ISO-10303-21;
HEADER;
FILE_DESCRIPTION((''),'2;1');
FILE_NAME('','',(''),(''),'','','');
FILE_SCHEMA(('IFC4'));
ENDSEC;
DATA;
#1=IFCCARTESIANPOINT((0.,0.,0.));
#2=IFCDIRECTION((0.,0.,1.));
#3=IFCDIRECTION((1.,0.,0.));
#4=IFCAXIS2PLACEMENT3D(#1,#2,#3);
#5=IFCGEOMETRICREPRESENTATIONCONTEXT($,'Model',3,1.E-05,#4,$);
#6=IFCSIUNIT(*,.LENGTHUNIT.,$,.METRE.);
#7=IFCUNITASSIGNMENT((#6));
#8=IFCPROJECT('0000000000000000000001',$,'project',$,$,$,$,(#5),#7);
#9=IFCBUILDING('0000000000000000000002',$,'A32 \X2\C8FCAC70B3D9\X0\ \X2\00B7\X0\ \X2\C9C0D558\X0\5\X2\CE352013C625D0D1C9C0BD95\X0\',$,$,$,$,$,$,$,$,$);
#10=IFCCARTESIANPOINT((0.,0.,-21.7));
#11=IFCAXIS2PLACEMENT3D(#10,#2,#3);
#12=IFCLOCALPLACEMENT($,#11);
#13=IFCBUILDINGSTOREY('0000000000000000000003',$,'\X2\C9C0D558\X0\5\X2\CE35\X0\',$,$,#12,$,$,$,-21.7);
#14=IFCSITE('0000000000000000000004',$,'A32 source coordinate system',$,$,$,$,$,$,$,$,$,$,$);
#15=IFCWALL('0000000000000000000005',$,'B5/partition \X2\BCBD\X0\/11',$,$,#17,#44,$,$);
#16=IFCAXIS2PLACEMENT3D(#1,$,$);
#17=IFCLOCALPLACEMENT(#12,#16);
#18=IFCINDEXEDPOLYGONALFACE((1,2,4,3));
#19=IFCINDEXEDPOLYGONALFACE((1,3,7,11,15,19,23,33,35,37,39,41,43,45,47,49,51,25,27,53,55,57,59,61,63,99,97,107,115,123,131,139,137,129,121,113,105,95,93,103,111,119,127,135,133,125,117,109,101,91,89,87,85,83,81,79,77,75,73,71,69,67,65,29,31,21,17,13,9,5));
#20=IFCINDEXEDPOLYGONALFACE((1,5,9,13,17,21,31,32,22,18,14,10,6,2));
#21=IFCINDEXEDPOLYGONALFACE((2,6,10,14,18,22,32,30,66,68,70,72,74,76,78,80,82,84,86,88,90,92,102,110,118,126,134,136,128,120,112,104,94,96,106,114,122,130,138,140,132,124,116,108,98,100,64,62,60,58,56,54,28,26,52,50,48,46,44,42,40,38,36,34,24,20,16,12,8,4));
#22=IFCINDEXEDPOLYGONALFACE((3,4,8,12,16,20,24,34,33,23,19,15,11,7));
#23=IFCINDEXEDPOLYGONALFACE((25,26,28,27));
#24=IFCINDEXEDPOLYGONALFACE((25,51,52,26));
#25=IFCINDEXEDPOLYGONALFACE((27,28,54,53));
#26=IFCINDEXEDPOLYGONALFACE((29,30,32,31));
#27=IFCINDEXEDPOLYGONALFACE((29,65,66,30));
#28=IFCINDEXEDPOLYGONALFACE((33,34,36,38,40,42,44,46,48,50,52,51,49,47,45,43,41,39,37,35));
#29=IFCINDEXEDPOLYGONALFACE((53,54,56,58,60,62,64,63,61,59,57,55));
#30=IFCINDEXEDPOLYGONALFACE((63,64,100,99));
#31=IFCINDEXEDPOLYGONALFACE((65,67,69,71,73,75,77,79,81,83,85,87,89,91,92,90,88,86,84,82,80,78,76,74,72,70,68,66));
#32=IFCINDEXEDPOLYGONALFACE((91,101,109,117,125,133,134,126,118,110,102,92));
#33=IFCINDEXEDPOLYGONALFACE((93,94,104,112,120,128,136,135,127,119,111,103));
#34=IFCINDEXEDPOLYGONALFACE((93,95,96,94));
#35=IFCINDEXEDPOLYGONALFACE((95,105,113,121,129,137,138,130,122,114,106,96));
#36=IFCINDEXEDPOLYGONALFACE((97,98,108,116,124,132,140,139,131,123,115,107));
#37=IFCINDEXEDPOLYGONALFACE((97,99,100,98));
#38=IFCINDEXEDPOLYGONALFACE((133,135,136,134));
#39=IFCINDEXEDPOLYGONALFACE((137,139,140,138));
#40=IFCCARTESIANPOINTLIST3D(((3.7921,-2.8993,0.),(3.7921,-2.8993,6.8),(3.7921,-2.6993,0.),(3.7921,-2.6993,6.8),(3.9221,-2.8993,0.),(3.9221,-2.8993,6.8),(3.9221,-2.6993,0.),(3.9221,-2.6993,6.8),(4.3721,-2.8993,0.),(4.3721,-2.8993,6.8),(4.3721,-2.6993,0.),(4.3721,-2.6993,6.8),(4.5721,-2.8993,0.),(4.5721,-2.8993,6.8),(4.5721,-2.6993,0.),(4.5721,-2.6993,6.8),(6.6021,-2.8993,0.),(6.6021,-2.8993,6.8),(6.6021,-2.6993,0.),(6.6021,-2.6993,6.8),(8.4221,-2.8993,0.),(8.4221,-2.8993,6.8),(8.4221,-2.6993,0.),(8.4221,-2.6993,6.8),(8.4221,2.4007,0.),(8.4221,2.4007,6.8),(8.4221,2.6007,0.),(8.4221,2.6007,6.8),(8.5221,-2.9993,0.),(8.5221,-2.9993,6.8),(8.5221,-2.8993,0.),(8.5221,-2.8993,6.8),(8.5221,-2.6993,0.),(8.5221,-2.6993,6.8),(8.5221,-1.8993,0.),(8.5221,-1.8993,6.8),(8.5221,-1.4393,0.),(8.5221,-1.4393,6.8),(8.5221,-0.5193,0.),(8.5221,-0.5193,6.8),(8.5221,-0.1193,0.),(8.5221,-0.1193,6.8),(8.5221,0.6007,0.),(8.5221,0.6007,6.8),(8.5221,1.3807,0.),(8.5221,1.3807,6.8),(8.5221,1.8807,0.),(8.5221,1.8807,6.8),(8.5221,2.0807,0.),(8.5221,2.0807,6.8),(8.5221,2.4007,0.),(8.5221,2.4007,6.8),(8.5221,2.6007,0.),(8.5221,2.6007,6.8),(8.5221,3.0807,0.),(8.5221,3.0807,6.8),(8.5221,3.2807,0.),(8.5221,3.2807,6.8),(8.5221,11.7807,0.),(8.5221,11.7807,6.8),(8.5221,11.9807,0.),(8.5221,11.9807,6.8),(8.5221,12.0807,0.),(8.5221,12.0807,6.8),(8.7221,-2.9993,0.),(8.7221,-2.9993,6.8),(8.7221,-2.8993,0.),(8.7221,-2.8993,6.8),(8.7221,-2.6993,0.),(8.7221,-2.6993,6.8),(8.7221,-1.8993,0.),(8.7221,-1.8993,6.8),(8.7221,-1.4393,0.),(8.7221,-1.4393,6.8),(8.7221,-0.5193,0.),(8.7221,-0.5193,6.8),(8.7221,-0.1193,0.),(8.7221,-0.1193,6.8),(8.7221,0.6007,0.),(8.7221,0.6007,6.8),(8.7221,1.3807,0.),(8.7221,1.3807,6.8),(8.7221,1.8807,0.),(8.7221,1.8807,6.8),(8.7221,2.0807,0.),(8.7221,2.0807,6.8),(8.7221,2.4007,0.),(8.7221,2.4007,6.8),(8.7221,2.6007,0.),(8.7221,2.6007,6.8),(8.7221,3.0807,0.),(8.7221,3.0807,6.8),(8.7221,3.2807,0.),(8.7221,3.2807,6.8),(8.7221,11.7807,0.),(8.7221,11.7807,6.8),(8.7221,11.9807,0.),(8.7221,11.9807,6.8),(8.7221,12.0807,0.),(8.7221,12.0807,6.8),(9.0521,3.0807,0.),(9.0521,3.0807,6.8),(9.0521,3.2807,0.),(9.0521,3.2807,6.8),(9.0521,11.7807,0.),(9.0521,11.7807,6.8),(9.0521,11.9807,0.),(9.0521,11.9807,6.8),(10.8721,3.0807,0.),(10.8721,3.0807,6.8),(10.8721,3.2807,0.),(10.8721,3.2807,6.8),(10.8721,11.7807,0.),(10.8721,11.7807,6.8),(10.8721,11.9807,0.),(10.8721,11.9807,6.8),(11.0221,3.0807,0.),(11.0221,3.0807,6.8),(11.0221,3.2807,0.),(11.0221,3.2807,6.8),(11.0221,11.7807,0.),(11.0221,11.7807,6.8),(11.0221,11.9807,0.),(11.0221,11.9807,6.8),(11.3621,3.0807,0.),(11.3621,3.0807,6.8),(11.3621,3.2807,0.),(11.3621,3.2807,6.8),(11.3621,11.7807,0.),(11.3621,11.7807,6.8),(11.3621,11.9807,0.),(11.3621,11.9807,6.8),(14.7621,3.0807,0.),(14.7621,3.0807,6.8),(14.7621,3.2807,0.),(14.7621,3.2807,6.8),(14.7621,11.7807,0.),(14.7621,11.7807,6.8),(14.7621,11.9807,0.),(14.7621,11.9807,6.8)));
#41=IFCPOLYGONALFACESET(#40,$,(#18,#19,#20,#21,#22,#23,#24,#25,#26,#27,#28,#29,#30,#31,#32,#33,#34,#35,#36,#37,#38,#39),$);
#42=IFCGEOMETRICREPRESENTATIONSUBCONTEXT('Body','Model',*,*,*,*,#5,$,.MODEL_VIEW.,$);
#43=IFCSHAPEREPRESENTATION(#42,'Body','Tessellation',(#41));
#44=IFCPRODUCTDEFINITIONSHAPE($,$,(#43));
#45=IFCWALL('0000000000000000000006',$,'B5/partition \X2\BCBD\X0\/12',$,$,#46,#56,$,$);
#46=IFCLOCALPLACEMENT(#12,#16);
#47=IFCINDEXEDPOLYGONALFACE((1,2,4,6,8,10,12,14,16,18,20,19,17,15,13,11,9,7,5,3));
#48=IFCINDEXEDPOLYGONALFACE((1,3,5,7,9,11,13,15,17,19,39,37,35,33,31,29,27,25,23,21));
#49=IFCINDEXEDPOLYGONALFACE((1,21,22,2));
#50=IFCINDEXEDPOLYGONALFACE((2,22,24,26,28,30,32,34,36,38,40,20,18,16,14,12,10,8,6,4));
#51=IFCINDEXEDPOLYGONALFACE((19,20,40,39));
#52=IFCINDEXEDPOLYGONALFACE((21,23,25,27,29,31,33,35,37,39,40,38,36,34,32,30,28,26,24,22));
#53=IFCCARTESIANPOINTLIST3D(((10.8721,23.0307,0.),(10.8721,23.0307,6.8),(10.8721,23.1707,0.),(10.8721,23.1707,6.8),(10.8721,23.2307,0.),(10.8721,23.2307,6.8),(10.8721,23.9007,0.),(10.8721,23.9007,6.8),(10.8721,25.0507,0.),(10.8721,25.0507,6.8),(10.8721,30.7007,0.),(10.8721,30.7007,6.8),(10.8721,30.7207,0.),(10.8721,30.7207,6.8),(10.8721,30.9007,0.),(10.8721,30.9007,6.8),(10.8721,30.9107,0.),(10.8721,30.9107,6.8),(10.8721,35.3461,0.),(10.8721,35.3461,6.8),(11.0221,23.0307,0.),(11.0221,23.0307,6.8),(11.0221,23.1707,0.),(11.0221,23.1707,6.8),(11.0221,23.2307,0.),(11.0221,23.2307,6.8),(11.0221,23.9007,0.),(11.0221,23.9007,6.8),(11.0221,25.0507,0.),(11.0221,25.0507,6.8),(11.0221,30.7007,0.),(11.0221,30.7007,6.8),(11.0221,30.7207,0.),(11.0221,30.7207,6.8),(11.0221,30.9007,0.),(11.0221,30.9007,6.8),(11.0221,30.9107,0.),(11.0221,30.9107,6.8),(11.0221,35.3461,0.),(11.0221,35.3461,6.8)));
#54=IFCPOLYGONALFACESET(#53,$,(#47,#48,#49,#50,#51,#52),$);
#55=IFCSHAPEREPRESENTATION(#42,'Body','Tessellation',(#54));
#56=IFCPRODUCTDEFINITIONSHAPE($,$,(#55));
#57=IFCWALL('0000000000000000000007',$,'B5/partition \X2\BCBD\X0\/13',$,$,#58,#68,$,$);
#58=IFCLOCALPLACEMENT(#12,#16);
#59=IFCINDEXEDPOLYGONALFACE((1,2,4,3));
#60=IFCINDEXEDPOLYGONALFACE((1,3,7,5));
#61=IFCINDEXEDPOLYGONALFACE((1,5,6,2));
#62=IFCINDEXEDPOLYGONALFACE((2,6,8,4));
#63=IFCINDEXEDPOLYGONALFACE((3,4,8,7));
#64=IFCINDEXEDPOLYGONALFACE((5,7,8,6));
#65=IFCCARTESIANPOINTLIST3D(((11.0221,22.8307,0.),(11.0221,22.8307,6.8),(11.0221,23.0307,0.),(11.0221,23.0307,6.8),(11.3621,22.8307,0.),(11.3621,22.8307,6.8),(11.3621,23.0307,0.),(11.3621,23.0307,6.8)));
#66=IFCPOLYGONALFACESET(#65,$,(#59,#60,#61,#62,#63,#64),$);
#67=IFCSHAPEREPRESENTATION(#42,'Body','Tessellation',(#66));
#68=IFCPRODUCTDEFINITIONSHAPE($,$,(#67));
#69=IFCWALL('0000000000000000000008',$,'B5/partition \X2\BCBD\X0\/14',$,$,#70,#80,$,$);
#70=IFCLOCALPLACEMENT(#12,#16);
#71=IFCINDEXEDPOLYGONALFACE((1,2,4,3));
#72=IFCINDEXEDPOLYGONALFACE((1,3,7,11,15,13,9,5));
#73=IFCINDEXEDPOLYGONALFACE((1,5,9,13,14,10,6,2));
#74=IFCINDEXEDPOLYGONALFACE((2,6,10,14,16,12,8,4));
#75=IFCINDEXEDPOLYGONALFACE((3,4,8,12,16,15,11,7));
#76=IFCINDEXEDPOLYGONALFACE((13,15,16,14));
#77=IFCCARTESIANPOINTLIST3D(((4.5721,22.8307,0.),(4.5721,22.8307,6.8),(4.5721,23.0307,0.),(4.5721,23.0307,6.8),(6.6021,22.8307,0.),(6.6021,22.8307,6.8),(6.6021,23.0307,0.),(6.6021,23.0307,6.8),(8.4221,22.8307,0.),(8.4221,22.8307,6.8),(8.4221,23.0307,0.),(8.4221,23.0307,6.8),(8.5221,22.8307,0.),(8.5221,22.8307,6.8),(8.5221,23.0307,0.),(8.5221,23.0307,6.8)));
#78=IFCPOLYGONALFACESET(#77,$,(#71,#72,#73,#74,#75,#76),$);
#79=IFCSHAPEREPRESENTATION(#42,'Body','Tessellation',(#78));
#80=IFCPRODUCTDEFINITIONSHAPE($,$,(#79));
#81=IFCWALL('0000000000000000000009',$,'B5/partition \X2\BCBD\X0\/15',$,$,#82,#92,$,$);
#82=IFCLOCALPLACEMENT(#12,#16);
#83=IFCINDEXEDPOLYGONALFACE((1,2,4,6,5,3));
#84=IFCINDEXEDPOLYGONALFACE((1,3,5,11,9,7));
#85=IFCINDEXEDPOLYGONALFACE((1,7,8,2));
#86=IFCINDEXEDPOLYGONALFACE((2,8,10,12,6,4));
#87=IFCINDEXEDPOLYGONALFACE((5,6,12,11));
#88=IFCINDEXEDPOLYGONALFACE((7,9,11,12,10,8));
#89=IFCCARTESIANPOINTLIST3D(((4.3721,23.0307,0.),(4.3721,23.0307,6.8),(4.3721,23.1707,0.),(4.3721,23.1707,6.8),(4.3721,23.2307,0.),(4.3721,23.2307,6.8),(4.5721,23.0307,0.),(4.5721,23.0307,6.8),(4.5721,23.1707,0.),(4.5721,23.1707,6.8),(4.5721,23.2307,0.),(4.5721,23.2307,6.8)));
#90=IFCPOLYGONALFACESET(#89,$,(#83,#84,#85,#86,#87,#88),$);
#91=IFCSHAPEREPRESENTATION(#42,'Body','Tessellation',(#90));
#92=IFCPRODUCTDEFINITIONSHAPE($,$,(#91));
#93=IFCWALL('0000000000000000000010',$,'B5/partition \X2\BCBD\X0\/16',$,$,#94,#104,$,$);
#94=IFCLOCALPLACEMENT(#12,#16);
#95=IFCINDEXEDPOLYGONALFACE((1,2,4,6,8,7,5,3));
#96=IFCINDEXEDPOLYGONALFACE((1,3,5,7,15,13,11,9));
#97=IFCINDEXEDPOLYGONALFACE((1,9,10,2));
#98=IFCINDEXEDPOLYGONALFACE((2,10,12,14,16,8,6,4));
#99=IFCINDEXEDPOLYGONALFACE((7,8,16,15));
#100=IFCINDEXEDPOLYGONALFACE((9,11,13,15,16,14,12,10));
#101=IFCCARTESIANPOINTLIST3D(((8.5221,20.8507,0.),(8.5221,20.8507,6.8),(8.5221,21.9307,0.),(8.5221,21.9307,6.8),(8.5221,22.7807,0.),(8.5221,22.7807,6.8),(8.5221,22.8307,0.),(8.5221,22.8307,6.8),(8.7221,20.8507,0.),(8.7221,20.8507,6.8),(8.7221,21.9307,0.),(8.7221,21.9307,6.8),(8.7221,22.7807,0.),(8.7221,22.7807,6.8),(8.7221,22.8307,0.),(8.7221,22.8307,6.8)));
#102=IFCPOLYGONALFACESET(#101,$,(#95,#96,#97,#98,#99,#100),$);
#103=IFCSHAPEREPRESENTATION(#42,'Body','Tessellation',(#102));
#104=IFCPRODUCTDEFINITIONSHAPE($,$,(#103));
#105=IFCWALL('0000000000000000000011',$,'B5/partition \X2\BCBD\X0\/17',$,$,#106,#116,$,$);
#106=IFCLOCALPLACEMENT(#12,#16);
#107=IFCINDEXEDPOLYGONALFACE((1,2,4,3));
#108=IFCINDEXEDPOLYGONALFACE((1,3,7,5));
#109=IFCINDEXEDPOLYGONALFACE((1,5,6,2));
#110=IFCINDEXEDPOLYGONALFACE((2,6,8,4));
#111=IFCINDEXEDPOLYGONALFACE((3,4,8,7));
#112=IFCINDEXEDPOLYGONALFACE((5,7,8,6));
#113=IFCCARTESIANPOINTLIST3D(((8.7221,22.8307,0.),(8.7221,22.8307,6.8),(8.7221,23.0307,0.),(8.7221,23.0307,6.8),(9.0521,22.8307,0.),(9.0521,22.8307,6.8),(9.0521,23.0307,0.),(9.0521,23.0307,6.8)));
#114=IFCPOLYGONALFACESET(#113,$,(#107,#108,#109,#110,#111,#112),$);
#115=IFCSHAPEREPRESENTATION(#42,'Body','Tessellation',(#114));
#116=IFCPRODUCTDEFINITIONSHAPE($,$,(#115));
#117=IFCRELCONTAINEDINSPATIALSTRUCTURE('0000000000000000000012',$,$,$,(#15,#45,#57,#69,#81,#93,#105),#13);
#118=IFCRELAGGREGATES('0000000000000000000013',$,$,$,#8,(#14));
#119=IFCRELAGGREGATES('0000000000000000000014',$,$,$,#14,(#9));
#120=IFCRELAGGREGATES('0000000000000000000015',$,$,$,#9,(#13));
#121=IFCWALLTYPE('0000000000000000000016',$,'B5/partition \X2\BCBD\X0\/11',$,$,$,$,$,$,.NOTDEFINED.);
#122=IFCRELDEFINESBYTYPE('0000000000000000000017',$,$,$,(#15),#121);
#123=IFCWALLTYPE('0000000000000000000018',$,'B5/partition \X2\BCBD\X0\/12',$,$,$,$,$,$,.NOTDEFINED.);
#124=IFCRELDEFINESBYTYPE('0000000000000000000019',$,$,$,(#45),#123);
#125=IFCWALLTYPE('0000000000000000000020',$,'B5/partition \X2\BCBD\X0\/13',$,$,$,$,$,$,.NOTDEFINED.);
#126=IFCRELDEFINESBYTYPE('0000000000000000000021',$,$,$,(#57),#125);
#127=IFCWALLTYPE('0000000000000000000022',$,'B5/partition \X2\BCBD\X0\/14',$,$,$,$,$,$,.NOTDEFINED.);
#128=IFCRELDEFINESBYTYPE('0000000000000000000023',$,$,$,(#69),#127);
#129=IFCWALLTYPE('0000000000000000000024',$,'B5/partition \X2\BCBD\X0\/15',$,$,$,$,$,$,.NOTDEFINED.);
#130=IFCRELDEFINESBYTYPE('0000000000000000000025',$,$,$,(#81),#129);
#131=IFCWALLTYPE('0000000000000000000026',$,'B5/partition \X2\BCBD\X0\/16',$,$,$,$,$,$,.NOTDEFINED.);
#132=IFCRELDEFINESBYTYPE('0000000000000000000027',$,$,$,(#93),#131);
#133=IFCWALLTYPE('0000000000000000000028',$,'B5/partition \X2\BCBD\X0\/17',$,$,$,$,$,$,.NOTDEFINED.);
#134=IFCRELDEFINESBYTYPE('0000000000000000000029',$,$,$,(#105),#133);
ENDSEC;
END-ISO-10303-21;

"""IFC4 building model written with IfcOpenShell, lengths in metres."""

from ifc_helpers import new_model, si_unit, frame, origin, origin_with_axes, place, context, subcontext, project, spatial, polyline, outline, extrude, source, transform, mapped, type_object, type_shapes, element, save


model = new_model("IFC4")

# Units and contexts
model_context = context("Model", 3, precision=1e-05, world=origin_with_axes())
body_context = subcontext(model_context, "Body", "Model", "MODEL_VIEW")
ifc_project = project(units=[si_unit("LENGTHUNIT", "METRE")], contexts=[model_context])

# Site, building, storey
site = spatial("IfcSite", under=ifc_project, Name="A32 source coordinate system")
building = spatial("IfcBuilding", under=site, Name="A32 주거동 · 지하5층–옥탑지붕")
storey_placement = place(None, frame((0.0, 0.0, -21.7), z_axis=(0.0, 0.0, 1.0), x_axis=(1.0, 0.0, 0.0)))
storey = spatial("IfcBuildingStorey", under=building, at=storey_placement, Name="지하5층", Elevation=-21.7)

# Walls
wall_type_1 = type_object("IfcWallType", Name="B5/partition 벽/11", PredefinedType="NOTDEFINED")
shared_shape_1 = source(origin(), body_context, "Body", "SweptSolid", [
    extrude(outline(polyline([(4.3721, -2.6993), (4.5721, -2.6993), (6.6021, -2.6993), (8.4221, -2.6993), (8.5221, -2.6993), (8.5221, -1.8993), (8.5221, -1.4393), (8.5221, -0.5193), (8.5221, -0.1193), (8.5221, 0.6007), (8.5221, 1.3807), (8.5221, 1.8807), (8.5221, 2.0807), (8.5221, 2.4007), (8.4221, 2.4007), (8.4221, 2.6007), (8.5221, 2.6007), (8.5221, 3.0807), (8.5221, 3.2807), (8.5221, 11.7807), (8.5221, 11.9807), (8.5221, 12.0807), (8.7221, 12.0807), (8.7221, 11.9807), (9.0521, 11.9807), (10.8721, 11.9807), (11.0221, 11.9807), (11.3621, 11.9807), (14.7621, 11.9807), (14.7621, 11.7807), (11.3621, 11.7807), (11.0221, 11.7807), (10.8721, 11.7807), (9.0521, 11.7807), (8.7221, 11.7807), (8.7221, 3.2807), (9.0521, 3.2807), (10.8721, 3.2807), (11.0221, 3.2807), (11.3621, 3.2807), (14.7621, 3.2807), (14.7621, 3.0807), (11.3621, 3.0807), (11.0221, 3.0807), (10.8721, 3.0807), (9.0521, 3.0807), (8.7221, 3.0807), (8.7221, 2.6007), (8.7221, 2.4007), (8.7221, 2.0807), (8.7221, 1.8807), (8.7221, 1.3807), (8.7221, 0.6007), (8.7221, -0.1193), (8.7221, -0.5193), (8.7221, -1.4393), (8.7221, -1.8993), (8.7221, -2.6993), (8.7221, -2.8993), (8.7221, -2.9993), (8.5221, -2.9993), (8.5221, -2.8993), (8.4221, -2.8993), (6.6021, -2.8993), (4.5721, -2.8993), (4.3721, -2.8993), (3.9221, -2.8993), (3.7921, -2.8993), (3.7921, -2.6993), (3.9221, -2.6993), (4.3721, -2.6993)])), origin(), (0.0, 0.0, 1.0), 6.8),
])
type_shapes(wall_type_1, [shared_shape_1])
wall_1_placement = place(storey_placement, origin_with_axes())
element("IfcWall", 1, at=wall_1_placement, inside=storey, type_object=wall_type_1, Name="B5/partition 벽/11", context=body_context, shape_type="MappedRepresentation", body=[
    mapped(shared_shape_1, transform((0.0, 0.0, 0.0), scale=1.0)),
])
wall_type_2 = type_object("IfcWallType", Name="B5/partition 벽/12", PredefinedType="NOTDEFINED")
shared_shape_2 = source(origin(), body_context, "Body", "SweptSolid", [
    extrude(outline(polyline([(10.8721, 30.9007), (10.8721, 30.9107), (10.8721, 35.3461), (11.0221, 35.3461), (11.0221, 30.9107), (11.0221, 30.9007), (11.0221, 30.7207), (11.0221, 30.7007), (11.0221, 25.0507), (11.0221, 23.9007), (11.0221, 23.2307), (11.0221, 23.1707), (11.0221, 23.0307), (10.8721, 23.0307), (10.8721, 23.1707), (10.8721, 23.2307), (10.8721, 23.9007), (10.8721, 25.0507), (10.8721, 30.7007), (10.8721, 30.7207), (10.8721, 30.9007)])), origin(), (0.0, 0.0, 1.0), 6.8),
])
type_shapes(wall_type_2, [shared_shape_2])
wall_2_placement = place(storey_placement, origin_with_axes())
element("IfcWall", 2, at=wall_2_placement, inside=storey, type_object=wall_type_2, Name="B5/partition 벽/12", context=body_context, shape_type="MappedRepresentation", body=[
    mapped(shared_shape_2, transform((0.0, 0.0, 0.0), scale=1.0)),
])
wall_type_3 = type_object("IfcWallType", Name="B5/partition 벽/13", PredefinedType="NOTDEFINED")
shared_shape_3 = source(origin(), body_context, "Body", "SweptSolid", [
    extrude(outline(polyline([(11.3621, 23.0307), (11.3621, 22.8307), (11.0221, 22.8307), (11.0221, 23.0307), (11.3621, 23.0307)])), origin(), (0.0, 0.0, 1.0), 6.8),
])
type_shapes(wall_type_3, [shared_shape_3])
wall_3_placement = place(storey_placement, origin_with_axes())
element("IfcWall", 3, at=wall_3_placement, inside=storey, type_object=wall_type_3, Name="B5/partition 벽/13", context=body_context, shape_type="MappedRepresentation", body=[
    mapped(shared_shape_3, transform((0.0, 0.0, 0.0), scale=1.0)),
])
wall_type_4 = type_object("IfcWallType", Name="B5/partition 벽/14", PredefinedType="NOTDEFINED")
shared_shape_4 = source(origin(), body_context, "Body", "SweptSolid", [
    extrude(outline(polyline([(6.6021, 23.0307), (8.4221, 23.0307), (8.5221, 23.0307), (8.5221, 22.8307), (8.4221, 22.8307), (6.6021, 22.8307), (4.5721, 22.8307), (4.5721, 23.0307), (6.6021, 23.0307)])), origin(), (0.0, 0.0, 1.0), 6.8),
])
type_shapes(wall_type_4, [shared_shape_4])
wall_4_placement = place(storey_placement, origin_with_axes())
element("IfcWall", 4, at=wall_4_placement, inside=storey, type_object=wall_type_4, Name="B5/partition 벽/14", context=body_context, shape_type="MappedRepresentation", body=[
    mapped(shared_shape_4, transform((0.0, 0.0, 0.0), scale=1.0)),
])
wall_type_5 = type_object("IfcWallType", Name="B5/partition 벽/15", PredefinedType="NOTDEFINED")
shared_shape_5 = source(origin(), body_context, "Body", "SweptSolid", [
    extrude(outline(polyline([(4.3721, 23.0307), (4.3721, 23.1707), (4.3721, 23.2307), (4.5721, 23.2307), (4.5721, 23.1707), (4.5721, 23.0307), (4.3721, 23.0307)])), origin(), (0.0, 0.0, 1.0), 6.8),
])
type_shapes(wall_type_5, [shared_shape_5])
wall_5_placement = place(storey_placement, origin_with_axes())
element("IfcWall", 5, at=wall_5_placement, inside=storey, type_object=wall_type_5, Name="B5/partition 벽/15", context=body_context, shape_type="MappedRepresentation", body=[
    mapped(shared_shape_5, transform((0.0, 0.0, 0.0), scale=1.0)),
])
wall_type_6 = type_object("IfcWallType", Name="B5/partition 벽/16", PredefinedType="NOTDEFINED")
shared_shape_6 = source(origin(), body_context, "Body", "SweptSolid", [
    extrude(outline(polyline([(8.7221, 22.8307), (8.7221, 22.7807), (8.7221, 21.9307), (8.7221, 20.8507), (8.5221, 20.8507), (8.5221, 21.9307), (8.5221, 22.7807), (8.5221, 22.8307), (8.7221, 22.8307)])), origin(), (0.0, 0.0, 1.0), 6.8),
])
type_shapes(wall_type_6, [shared_shape_6])
wall_6_placement = place(storey_placement, origin_with_axes())
element("IfcWall", 6, at=wall_6_placement, inside=storey, type_object=wall_type_6, Name="B5/partition 벽/16", context=body_context, shape_type="MappedRepresentation", body=[
    mapped(shared_shape_6, transform((0.0, 0.0, 0.0), scale=1.0)),
])
wall_type_7 = type_object("IfcWallType", Name="B5/partition 벽/17", PredefinedType="NOTDEFINED")
shared_shape_7 = source(origin(), body_context, "Body", "SweptSolid", [
    extrude(outline(polyline([(8.7221, 23.0307), (9.0521, 23.0307), (9.0521, 22.8307), (8.7221, 22.8307), (8.7221, 23.0307)])), origin(), (0.0, 0.0, 1.0), 6.8),
])
type_shapes(wall_type_7, [shared_shape_7])
wall_7_placement = place(storey_placement, origin_with_axes())
element("IfcWall", 7, at=wall_7_placement, inside=storey, type_object=wall_type_7, Name="B5/partition 벽/17", context=body_context, shape_type="MappedRepresentation", body=[
    mapped(shared_shape_7, transform((0.0, 0.0, 0.0), scale=1.0)),
])

save(model, "model.ifc")
